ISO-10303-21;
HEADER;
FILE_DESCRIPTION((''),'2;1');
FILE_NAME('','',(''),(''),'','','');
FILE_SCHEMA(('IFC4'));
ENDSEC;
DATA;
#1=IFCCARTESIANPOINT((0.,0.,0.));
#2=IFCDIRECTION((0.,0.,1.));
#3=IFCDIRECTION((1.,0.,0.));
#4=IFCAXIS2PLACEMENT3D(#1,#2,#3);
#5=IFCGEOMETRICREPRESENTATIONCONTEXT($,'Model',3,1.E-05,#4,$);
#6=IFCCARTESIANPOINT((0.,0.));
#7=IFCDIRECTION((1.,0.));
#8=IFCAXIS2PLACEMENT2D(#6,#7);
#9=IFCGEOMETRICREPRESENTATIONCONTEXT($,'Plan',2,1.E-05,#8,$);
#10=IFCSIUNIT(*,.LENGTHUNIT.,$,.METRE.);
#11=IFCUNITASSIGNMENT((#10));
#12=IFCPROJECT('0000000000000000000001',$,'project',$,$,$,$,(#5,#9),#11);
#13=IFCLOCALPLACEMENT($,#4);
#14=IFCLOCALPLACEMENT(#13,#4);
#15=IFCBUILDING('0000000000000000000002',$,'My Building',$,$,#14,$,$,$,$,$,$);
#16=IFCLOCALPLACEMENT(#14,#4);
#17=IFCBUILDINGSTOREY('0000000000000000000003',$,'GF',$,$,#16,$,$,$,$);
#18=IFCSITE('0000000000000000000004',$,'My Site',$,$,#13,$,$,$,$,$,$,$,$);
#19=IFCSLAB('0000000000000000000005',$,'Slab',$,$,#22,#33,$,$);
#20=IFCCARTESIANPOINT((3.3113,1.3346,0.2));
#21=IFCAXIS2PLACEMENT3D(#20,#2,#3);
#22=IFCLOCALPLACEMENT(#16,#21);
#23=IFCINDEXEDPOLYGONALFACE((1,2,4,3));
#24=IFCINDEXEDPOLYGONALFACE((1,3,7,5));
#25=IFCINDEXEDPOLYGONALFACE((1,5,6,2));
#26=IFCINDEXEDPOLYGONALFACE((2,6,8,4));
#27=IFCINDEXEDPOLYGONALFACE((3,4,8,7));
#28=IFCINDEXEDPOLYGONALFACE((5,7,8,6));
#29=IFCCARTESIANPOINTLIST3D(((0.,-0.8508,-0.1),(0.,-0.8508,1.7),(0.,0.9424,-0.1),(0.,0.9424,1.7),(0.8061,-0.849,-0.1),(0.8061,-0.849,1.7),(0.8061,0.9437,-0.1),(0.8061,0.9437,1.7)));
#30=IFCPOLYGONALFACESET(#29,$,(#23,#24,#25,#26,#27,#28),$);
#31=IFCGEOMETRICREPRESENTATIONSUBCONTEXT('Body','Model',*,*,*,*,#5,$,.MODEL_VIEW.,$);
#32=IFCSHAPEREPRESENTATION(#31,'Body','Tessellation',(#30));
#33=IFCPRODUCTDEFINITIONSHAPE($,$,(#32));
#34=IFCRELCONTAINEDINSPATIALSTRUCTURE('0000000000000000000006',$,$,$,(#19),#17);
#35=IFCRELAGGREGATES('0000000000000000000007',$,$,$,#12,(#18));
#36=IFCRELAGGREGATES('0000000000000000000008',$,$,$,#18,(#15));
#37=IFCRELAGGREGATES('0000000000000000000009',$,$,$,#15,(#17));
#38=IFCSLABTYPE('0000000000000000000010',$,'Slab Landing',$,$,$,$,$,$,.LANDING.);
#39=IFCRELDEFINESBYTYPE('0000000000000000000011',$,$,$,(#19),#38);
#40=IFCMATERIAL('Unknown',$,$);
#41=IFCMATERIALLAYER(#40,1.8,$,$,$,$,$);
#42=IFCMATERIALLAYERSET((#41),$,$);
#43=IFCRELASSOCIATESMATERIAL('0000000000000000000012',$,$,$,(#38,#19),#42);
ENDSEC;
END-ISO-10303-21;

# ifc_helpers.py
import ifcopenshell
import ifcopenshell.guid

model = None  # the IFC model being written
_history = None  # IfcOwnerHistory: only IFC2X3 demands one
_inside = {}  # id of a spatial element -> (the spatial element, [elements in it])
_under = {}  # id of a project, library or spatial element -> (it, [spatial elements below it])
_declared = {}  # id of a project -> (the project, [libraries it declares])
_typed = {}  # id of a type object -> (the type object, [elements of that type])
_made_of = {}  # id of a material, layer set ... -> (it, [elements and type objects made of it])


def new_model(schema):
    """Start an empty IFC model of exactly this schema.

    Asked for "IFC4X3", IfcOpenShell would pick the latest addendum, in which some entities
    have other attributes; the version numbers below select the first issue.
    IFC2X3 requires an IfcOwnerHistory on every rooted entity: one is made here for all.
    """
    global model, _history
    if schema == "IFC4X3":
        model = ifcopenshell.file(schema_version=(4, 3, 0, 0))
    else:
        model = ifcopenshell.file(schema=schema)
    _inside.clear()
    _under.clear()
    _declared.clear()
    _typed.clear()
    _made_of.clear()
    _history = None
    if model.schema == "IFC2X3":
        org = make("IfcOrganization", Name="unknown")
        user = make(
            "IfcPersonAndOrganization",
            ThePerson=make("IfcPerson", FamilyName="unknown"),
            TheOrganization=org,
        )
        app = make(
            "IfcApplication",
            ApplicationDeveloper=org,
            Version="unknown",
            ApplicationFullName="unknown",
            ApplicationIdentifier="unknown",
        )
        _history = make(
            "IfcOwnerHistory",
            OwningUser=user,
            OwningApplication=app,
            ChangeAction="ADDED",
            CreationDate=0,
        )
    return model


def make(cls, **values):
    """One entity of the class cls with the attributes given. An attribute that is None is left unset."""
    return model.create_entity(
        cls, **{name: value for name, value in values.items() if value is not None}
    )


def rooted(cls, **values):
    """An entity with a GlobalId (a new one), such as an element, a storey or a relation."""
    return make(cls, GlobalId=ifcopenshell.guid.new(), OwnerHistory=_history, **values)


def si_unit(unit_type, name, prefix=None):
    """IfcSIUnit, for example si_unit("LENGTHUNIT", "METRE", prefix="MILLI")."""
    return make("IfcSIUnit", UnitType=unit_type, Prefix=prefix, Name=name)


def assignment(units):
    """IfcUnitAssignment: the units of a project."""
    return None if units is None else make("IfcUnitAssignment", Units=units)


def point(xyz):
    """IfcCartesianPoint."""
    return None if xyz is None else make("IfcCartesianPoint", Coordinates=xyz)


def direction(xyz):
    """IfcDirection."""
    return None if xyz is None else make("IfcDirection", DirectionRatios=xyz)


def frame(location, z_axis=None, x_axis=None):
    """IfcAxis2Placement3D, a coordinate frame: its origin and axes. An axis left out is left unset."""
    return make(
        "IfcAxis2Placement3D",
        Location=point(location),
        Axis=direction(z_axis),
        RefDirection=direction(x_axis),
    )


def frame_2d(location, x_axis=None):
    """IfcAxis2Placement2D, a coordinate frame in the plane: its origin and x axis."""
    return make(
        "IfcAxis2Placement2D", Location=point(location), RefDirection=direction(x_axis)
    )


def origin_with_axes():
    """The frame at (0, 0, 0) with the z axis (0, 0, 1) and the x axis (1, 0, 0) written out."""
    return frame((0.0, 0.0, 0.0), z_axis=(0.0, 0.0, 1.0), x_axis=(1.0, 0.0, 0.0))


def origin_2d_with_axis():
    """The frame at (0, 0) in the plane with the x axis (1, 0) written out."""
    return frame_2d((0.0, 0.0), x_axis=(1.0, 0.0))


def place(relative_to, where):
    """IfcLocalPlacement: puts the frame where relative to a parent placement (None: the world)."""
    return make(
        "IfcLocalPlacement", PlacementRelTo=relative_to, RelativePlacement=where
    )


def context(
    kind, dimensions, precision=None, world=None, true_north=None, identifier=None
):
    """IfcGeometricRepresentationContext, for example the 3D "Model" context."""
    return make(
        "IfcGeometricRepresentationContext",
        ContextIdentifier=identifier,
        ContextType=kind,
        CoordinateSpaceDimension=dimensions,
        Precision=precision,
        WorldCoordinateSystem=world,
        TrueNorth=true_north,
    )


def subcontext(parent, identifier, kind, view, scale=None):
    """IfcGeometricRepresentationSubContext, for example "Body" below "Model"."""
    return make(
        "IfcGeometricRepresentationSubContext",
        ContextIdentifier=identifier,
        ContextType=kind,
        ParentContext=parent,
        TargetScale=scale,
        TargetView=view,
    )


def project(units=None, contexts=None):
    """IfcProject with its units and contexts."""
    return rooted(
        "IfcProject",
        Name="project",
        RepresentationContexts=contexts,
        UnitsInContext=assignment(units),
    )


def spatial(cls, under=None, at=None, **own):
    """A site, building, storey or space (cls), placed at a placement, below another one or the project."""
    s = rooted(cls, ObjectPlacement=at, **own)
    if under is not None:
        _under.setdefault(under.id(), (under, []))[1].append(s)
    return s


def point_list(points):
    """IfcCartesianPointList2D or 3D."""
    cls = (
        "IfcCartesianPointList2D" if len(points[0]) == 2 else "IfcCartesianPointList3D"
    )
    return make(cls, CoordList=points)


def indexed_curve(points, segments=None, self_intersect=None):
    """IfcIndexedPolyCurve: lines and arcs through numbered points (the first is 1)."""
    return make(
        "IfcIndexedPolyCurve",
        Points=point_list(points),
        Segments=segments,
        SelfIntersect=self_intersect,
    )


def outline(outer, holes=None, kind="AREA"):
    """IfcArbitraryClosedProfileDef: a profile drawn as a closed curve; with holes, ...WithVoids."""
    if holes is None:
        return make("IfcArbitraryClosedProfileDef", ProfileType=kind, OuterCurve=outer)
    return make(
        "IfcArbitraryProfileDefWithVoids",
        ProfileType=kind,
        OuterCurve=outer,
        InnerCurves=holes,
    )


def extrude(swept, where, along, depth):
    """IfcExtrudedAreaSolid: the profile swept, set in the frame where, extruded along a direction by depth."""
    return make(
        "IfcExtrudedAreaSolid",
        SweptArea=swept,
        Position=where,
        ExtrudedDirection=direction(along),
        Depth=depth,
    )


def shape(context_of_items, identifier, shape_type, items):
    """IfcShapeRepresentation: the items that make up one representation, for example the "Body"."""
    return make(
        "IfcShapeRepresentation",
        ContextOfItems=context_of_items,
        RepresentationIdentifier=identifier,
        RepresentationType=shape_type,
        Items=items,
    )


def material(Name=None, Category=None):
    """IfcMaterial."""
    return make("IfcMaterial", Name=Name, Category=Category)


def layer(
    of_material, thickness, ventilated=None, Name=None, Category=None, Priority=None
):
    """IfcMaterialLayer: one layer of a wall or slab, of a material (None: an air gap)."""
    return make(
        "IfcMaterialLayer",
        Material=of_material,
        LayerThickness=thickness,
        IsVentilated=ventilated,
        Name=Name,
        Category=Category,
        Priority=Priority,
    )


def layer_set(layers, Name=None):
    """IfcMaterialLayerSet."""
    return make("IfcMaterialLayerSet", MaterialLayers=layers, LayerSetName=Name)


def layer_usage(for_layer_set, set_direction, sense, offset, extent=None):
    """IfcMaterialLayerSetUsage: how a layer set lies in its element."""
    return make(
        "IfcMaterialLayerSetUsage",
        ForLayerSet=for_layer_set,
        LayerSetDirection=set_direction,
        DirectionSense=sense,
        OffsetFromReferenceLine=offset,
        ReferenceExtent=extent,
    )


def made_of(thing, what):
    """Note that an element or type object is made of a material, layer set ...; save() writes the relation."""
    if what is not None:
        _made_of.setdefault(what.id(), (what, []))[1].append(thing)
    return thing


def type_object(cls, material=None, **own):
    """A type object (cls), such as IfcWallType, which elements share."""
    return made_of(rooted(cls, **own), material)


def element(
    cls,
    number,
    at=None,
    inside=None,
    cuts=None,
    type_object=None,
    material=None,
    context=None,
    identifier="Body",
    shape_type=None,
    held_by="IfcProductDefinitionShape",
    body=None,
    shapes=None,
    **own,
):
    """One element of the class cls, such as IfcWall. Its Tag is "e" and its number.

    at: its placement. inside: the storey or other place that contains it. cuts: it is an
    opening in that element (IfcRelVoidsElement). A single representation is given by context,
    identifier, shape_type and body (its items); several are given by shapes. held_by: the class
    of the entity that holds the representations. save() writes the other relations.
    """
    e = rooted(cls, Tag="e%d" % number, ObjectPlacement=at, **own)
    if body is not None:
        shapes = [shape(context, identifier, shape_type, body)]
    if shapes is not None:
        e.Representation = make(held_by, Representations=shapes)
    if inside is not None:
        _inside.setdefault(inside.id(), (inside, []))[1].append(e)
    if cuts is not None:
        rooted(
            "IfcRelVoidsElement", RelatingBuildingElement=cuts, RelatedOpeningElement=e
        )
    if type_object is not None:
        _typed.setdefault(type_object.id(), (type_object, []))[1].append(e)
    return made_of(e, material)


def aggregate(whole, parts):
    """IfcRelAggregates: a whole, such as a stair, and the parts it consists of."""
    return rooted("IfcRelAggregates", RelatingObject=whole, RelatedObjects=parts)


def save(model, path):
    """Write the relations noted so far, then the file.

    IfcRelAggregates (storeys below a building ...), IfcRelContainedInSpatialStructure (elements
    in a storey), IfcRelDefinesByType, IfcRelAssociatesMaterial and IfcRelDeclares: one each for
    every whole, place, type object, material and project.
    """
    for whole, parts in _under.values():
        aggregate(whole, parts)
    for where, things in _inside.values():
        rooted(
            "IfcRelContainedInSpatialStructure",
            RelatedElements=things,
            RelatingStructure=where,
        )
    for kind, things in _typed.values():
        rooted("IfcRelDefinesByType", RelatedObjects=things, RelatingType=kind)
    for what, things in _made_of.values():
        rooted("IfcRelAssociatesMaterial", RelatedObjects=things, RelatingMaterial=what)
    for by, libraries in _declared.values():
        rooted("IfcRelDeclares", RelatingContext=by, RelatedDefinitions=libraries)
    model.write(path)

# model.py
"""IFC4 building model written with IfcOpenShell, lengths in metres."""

from ifc_helpers import new_model, si_unit, frame, origin_with_axes, origin_2d_with_axis, place, context, subcontext, project, spatial, indexed_curve, outline, extrude, material, layer, layer_set, layer_usage, type_object, element, save


model = new_model("IFC4")

# Units and contexts
model_context = context("Model", 3, precision=1e-05, world=origin_with_axes())
plan_context = context("Plan", 2, precision=1e-05, world=origin_2d_with_axis())
body_context_1 = subcontext(model_context, "Body", "Model", "MODEL_VIEW")
ifc_project = project(units=[si_unit("LENGTHUNIT", "METRE")], contexts=[model_context, plan_context])

# Site, building, storey
site_placement = place(None, origin_with_axes())
site = spatial("IfcSite", under=ifc_project, at=site_placement, Name="My Site")
building_placement = place(site_placement, origin_with_axes())
building = spatial("IfcBuilding", under=site, at=building_placement, Name="My Building")
storey_placement = place(building_placement, origin_with_axes())
storey = spatial("IfcBuildingStorey", under=building, at=storey_placement, Name="GF")

# Shared definitions
ifc_material = material(Name="Unknown")

# Slab
ifc_layer_1 = layer(ifc_material, 1.8)
ifc_layer_set_1 = layer_set([ifc_layer_1])
ifc_layer_usage_1 = layer_usage(ifc_layer_set_1, "AXIS3", "POSITIVE", -0.1)
slab_type_1 = type_object("IfcSlabType", Name="Slab Landing", PredefinedType="LANDING", material=ifc_layer_set_1)
slab_1_placement = place(storey_placement, frame((3.3113, 1.3346, 0.2), z_axis=(0.0, 0.0, 1.0), x_axis=(1.0, 0.0, 0.0)))
element("IfcSlab", 1, at=slab_1_placement, inside=storey, type_object=slab_type_1, material=ifc_layer_usage_1, Name="Slab", context=body_context_1, shape_type="SweptSolid", body=[
    extrude(outline(indexed_curve([(0.0, 0.9424), (0.0, -0.8508), (0.8061, -0.849), (0.8061, 0.9437), (0.0, 0.9424)])), frame((0.0, 0.0, -0.1), z_axis=(0.0, 0.0, 1.0), x_axis=(1.0, 0.0, 0.0)), (0.0, 0.0, 1.0), 1.8),
])

save(model, "model.ifc")
